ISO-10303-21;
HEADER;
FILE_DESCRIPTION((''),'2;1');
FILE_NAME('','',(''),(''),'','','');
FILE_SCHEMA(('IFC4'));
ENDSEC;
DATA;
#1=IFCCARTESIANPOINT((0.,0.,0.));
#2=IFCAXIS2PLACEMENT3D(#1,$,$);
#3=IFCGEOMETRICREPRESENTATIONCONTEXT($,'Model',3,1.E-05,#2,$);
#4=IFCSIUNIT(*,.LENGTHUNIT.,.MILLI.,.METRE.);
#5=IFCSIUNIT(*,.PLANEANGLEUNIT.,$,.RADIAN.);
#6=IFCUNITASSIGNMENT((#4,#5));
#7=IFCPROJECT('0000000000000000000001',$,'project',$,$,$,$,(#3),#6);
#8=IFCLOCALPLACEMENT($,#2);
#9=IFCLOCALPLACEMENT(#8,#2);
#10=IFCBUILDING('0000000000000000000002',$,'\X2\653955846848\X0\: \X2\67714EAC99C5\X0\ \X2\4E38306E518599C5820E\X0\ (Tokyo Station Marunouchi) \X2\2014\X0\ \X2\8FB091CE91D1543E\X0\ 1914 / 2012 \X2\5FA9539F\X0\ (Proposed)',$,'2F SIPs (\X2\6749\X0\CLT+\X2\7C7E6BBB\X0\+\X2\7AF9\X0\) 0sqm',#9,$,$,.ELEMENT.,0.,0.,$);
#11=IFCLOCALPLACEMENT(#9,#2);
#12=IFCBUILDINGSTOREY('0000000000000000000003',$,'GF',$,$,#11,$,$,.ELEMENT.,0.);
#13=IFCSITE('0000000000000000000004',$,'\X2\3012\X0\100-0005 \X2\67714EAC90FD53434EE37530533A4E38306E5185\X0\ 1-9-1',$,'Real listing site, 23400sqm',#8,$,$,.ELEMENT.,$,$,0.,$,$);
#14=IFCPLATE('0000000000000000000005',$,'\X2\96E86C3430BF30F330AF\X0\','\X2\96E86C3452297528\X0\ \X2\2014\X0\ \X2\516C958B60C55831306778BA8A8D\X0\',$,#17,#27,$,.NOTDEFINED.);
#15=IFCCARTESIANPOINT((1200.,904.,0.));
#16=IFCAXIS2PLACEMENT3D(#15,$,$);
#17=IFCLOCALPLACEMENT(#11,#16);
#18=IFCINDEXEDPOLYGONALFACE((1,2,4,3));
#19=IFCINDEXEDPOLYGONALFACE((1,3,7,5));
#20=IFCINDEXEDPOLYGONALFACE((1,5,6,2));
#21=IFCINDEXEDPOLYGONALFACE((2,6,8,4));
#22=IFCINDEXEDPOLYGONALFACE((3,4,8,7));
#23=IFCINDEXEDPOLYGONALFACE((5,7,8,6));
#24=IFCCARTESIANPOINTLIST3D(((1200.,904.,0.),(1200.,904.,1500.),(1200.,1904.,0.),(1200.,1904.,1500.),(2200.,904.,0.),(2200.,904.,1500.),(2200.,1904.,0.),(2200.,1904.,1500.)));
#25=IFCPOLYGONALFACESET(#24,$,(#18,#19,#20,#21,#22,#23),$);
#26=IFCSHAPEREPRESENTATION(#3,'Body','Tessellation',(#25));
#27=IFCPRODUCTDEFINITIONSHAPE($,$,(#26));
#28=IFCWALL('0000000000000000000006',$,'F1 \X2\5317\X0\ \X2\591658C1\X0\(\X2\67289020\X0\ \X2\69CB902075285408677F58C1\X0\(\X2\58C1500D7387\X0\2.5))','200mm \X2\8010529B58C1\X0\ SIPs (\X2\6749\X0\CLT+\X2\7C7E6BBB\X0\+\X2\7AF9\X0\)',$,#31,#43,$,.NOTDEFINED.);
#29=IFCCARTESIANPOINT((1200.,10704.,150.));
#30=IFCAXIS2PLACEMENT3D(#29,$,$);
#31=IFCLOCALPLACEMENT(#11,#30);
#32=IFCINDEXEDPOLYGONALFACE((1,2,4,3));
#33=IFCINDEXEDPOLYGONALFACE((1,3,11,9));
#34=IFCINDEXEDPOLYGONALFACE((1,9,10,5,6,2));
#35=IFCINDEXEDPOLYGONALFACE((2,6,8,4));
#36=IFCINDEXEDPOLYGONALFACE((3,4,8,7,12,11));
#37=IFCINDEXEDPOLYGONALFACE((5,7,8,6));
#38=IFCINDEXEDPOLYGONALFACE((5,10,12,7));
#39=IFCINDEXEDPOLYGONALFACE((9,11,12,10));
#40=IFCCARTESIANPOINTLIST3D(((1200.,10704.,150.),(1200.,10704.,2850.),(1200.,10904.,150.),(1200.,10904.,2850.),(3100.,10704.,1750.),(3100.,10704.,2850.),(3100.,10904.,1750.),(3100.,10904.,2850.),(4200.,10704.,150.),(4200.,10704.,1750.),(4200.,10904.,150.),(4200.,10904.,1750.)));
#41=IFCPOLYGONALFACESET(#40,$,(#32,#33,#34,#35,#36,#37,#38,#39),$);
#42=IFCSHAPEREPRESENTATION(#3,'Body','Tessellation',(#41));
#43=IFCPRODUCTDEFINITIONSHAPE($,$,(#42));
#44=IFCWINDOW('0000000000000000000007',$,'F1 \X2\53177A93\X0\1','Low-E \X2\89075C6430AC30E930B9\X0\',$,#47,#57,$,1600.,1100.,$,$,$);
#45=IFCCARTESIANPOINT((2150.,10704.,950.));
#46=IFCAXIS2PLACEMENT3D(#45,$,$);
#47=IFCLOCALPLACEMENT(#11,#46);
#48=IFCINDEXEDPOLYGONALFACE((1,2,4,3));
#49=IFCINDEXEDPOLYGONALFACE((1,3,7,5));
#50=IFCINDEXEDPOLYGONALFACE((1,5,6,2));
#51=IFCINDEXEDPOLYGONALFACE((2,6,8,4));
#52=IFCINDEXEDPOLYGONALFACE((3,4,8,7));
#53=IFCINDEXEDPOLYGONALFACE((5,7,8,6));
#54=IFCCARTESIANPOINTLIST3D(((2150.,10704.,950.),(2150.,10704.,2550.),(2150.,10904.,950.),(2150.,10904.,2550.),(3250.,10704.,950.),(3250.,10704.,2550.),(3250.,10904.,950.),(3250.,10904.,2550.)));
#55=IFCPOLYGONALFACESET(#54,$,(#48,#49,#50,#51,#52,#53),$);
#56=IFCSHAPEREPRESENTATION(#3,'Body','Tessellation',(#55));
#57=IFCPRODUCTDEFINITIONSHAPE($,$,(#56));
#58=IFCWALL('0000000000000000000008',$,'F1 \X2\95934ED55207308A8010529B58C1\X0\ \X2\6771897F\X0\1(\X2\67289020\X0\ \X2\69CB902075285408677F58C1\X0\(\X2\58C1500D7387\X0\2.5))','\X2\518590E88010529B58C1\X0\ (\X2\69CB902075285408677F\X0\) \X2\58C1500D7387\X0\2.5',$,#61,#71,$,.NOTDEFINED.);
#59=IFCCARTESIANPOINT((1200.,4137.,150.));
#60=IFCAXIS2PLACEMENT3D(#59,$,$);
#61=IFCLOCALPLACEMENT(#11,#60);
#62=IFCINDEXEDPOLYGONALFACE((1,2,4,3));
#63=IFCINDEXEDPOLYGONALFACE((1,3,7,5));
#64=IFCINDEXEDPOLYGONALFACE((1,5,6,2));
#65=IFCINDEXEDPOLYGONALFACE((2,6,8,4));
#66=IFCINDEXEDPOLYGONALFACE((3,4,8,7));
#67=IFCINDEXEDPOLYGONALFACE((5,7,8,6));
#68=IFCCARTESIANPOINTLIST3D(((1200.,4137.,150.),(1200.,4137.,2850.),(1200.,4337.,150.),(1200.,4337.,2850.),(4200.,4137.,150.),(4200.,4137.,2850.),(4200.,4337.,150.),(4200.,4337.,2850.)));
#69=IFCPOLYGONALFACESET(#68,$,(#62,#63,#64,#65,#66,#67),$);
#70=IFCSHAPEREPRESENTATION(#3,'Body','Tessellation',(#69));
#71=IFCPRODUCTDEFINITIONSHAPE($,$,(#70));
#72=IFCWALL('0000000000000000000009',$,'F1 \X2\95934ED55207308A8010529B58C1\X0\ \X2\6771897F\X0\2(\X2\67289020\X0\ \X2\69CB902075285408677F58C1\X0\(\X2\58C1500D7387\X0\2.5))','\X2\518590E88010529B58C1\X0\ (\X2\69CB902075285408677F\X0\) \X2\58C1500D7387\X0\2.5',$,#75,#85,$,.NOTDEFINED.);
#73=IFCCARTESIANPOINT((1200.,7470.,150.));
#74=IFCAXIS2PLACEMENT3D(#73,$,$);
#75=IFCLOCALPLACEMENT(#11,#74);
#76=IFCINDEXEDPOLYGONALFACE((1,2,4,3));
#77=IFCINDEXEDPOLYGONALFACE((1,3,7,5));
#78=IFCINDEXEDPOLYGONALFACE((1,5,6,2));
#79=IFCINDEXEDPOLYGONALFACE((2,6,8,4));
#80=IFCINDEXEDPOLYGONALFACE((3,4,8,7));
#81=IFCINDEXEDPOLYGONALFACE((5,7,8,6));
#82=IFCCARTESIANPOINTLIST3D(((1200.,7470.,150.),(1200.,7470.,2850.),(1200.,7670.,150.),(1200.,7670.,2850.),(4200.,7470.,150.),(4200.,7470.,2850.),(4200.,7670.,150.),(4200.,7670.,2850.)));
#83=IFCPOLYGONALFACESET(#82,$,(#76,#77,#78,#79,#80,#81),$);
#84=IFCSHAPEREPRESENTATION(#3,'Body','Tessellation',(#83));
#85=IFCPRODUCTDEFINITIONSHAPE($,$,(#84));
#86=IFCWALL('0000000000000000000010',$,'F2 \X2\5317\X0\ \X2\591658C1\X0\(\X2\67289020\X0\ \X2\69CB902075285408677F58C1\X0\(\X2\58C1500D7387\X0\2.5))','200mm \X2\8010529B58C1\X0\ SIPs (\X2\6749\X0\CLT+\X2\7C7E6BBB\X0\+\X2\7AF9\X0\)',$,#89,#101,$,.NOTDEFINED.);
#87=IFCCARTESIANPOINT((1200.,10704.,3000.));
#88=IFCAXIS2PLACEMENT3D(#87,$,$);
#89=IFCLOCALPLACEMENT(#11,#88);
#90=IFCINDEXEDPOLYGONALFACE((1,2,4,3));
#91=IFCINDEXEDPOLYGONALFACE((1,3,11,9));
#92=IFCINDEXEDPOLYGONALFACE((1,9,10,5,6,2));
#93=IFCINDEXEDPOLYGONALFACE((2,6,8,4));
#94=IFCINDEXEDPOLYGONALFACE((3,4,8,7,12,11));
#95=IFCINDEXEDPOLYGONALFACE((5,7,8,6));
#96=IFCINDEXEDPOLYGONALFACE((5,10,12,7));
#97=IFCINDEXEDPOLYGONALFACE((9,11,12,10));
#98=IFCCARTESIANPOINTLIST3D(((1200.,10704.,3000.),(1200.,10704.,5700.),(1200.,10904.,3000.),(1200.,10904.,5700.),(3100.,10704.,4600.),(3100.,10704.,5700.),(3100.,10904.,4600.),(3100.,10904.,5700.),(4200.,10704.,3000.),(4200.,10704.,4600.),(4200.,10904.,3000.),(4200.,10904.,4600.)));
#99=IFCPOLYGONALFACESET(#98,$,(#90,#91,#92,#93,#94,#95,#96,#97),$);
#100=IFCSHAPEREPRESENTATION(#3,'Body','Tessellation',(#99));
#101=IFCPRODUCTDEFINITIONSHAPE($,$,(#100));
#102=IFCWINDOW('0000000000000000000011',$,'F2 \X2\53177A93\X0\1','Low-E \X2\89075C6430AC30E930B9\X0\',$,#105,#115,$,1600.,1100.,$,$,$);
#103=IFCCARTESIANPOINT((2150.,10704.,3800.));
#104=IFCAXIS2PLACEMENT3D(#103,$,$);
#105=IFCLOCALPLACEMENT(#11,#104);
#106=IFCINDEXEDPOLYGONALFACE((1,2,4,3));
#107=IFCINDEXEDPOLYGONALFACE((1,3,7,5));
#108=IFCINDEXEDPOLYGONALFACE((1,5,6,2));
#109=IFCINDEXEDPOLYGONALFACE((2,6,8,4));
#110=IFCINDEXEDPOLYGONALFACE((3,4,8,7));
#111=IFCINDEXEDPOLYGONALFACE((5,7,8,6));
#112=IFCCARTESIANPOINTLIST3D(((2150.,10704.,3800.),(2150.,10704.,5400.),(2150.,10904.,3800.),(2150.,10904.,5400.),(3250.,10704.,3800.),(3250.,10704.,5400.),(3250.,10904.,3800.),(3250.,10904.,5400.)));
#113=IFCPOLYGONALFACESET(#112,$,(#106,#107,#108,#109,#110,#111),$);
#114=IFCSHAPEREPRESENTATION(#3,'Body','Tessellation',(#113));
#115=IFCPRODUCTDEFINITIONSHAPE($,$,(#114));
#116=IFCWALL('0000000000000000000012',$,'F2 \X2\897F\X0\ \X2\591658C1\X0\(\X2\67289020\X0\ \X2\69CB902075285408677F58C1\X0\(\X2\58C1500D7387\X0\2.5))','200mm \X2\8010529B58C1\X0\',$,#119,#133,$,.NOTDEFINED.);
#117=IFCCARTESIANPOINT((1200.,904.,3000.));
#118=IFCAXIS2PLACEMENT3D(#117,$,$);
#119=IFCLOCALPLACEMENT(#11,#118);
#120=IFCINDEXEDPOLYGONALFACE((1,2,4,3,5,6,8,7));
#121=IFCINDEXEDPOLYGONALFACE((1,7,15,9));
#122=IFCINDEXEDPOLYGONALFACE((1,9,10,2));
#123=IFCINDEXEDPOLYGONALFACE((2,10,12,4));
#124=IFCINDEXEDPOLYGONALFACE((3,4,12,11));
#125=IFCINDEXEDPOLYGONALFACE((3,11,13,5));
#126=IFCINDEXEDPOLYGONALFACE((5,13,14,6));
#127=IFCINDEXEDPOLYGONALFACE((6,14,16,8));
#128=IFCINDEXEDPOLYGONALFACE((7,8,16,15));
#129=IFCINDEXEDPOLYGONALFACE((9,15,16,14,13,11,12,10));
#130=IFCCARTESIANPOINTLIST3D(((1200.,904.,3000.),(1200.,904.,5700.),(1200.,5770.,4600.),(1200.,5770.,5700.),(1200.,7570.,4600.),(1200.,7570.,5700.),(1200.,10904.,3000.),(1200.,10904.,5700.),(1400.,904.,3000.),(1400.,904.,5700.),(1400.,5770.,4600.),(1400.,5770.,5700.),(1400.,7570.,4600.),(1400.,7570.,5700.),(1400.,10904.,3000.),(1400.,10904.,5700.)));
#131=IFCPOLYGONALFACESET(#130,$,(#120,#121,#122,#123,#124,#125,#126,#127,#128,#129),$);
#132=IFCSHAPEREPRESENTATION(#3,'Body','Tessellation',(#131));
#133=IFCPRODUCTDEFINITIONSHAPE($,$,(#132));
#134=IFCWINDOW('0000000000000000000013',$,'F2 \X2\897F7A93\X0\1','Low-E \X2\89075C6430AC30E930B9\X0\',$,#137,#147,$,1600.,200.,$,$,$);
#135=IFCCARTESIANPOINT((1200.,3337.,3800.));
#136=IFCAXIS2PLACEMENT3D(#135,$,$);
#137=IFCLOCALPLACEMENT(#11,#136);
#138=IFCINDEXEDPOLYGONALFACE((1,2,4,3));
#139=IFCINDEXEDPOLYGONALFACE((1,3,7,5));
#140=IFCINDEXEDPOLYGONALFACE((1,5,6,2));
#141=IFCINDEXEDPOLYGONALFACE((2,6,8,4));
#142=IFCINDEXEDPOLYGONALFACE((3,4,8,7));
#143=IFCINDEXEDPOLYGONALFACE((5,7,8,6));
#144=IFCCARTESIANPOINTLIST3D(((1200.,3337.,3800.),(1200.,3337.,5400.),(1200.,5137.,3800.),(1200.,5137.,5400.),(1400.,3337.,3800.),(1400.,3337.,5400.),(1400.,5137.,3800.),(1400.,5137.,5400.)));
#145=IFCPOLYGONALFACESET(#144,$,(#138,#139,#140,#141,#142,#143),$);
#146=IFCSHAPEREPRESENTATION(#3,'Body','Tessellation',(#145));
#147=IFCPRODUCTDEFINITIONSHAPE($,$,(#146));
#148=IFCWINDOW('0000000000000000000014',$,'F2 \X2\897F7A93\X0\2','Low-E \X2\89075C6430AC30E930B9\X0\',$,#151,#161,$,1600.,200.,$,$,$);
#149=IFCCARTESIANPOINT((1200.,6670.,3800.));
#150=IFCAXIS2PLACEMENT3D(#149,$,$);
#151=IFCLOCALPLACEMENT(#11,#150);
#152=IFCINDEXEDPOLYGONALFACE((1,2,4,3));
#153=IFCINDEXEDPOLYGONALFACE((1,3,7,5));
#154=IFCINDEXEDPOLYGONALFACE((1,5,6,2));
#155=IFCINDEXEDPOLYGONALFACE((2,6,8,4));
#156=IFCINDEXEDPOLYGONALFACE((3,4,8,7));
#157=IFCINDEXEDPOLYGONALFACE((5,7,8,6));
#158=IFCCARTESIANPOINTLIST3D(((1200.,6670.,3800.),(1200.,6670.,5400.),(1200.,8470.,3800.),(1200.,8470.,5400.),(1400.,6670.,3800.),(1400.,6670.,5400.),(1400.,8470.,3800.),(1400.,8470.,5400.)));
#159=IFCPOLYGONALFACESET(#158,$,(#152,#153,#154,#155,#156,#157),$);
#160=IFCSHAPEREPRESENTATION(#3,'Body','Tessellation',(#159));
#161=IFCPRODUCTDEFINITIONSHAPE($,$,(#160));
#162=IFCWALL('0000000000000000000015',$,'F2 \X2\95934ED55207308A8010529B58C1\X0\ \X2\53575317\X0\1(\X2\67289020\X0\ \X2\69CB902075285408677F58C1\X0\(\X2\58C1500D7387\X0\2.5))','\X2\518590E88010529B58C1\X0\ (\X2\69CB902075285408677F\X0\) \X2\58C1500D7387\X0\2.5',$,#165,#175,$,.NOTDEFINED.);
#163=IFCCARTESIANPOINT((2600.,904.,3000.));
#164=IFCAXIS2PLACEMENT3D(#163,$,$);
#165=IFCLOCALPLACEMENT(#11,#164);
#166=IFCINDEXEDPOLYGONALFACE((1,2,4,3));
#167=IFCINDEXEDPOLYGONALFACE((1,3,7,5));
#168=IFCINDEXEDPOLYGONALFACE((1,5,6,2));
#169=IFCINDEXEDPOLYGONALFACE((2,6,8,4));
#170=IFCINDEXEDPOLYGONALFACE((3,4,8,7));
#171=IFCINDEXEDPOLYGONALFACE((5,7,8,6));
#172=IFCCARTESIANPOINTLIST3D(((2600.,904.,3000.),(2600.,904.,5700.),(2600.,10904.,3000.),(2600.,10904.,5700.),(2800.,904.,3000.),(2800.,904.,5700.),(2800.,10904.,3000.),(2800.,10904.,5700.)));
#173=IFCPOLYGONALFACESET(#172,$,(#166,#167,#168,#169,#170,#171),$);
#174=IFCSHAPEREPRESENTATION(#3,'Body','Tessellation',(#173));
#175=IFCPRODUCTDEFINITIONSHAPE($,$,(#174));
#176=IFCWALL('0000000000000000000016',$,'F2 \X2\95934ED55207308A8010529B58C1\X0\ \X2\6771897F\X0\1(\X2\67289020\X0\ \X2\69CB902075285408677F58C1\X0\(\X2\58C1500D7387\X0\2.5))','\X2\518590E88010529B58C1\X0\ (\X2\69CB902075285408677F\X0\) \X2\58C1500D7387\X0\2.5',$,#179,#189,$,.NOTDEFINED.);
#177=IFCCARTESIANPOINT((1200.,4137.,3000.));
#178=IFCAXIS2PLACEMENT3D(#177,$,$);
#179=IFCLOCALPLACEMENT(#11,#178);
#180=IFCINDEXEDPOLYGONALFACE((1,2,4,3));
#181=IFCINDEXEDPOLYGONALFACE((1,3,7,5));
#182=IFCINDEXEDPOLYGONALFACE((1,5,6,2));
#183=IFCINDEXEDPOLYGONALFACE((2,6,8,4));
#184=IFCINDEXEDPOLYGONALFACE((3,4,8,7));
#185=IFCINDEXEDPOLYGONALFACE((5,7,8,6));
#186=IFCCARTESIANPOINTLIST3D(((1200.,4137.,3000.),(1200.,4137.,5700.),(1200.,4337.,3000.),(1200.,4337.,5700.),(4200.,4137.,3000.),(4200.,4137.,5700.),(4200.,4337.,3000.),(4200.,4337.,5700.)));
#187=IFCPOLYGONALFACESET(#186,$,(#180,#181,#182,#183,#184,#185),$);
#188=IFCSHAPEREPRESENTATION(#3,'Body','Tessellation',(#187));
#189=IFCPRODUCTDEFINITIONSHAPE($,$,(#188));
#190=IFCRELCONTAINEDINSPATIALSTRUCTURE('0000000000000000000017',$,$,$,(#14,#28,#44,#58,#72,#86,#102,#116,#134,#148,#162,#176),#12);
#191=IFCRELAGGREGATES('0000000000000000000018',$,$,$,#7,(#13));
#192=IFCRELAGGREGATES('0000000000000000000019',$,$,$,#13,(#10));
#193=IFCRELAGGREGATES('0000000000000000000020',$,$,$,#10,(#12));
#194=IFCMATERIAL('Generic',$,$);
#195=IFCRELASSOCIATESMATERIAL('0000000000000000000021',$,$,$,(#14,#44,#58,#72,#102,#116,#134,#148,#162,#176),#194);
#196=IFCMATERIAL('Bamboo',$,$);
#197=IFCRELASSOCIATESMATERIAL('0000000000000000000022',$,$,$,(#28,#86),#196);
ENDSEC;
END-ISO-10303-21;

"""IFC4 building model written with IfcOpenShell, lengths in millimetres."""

from ifc_helpers import new_model, si_unit, frame, frame_2d, origin, place, context, project, spatial, rectangle, extrude, material, element, fill, save


model = new_model("IFC4")

# Units and contexts
model_context = context("Model", 3, precision=1e-05, world=origin())
ifc_project = project(units=[si_unit("LENGTHUNIT", "METRE", prefix="MILLI"), si_unit("PLANEANGLEUNIT", "RADIAN")], contexts=[model_context])

# Site, building, storey
site_placement = place(None, origin())
site = spatial("IfcSite", under=ifc_project, at=site_placement, Name="〒100-0005 東京都千代田区丸の内 1-9-1", ObjectType="Real listing site, 23400sqm", CompositionType="ELEMENT", RefElevation=0.0)
building_placement = place(site_placement, origin())
building = spatial("IfcBuilding", under=site, at=building_placement, Name="改善案: 東京駅 丸の内駅舎 (Tokyo Station Marunouchi) — 辰野金吾 1914 / 2012 復原 (Proposed)", ObjectType="2F SIPs (杉CLT+籾殻+竹) 0sqm", CompositionType="ELEMENT", ElevationOfRefHeight=0.0, ElevationOfTerrain=0.0)
storey_placement = place(building_placement, origin())
storey = spatial("IfcBuildingStorey", under=building, at=storey_placement, Name="GF", CompositionType="ELEMENT", Elevation=0.0)

# Plate
ifc_material_1 = material(Name="Generic")
plate_placement = place(storey_placement, frame((1200.0, 904.0, 0.0)))
element("IfcPlate", 1, at=plate_placement, inside=storey, material=ifc_material_1, Name="雨水タンク", Description="雨水利用 — 公開情報で確認", PredefinedType="NOTDEFINED", context=model_context, shape_type="SweptSolid", body=[
    extrude(rectangle(XDim=1000.0, YDim=1000.0, at=frame_2d((500.0, 500.0))), frame((1200.0, 904.0, 0.0)), (0.0, 0.0, 1.0), 1500.0),
])

# Wall, opening, window
ifc_material_2 = material(Name="Bamboo")
wall_1_placement = place(storey_placement, frame((1200.0, 10704.0, 150.0)))
wall_1 = element("IfcWall", 2, at=wall_1_placement, inside=storey, material=ifc_material_2, Name="F1 北 外壁(木造 構造用合板壁(壁倍率2.5))", Description="200mm 耐力壁 SIPs (杉CLT+籾殻+竹)", PredefinedType="NOTDEFINED", context=model_context, shape_type="SweptSolid", body=[
    extrude(rectangle(XDim=3000.0, YDim=200.0, at=frame_2d((1500.0, 100.0))), frame((1200.0, 10704.0, 150.0)), (0.0, 0.0, 1.0), 2700.0),
])
opening_1_placement = place(storey_placement, frame((2150.0, 10704.0, 950.0)))
opening_1 = element("IfcOpeningElement", 3, at=opening_1_placement, cuts=wall_1, PredefinedType="NOTDEFINED", context=model_context, shape_type="SweptSolid", body=[
    extrude(rectangle(XDim=1100.0, YDim=200.0, at=frame_2d((550.0, 100.0))), frame((2150.0, 10704.0, 950.0)), (0.0, 0.0, 1.0), 1600.0),
])
window_1_placement = place(storey_placement, frame((2150.0, 10704.0, 950.0)))
window_1 = element("IfcWindow", 4, at=window_1_placement, inside=storey, material=ifc_material_1, Name="F1 北窓1", Description="Low-E 複層ガラス", OverallHeight=1600.0, OverallWidth=1100.0, context=model_context, shape_type="SweptSolid", body=[
    extrude(rectangle(XDim=1100.0, YDim=200.0, at=frame_2d((550.0, 100.0))), frame((2150.0, 10704.0, 950.0)), (0.0, 0.0, 1.0), 1600.0),
])
fill(opening_1, window_1)

# Walls
wall_2_placement = place(storey_placement, frame((1200.0, 4137.0, 150.0)))
element("IfcWall", 5, at=wall_2_placement, inside=storey, material=ifc_material_1, Name="F1 間仕切り耐力壁 東西1(木造 構造用合板壁(壁倍率2.5))", Description="内部耐力壁 (構造用合板) 壁倍率2.5", PredefinedType="NOTDEFINED", context=model_context, shape_type="SweptSolid", body=[
    extrude(rectangle(XDim=3000.0, YDim=200.0, at=frame_2d((1500.0, 100.0))), frame((1200.0, 4137.0, 150.0)), (0.0, 0.0, 1.0), 2700.0),
])
wall_3_placement = place(storey_placement, frame((1200.0, 7470.0, 150.0)))
element("IfcWall", 6, at=wall_3_placement, inside=storey, material=ifc_material_1, Name="F1 間仕切り耐力壁 東西2(木造 構造用合板壁(壁倍率2.5))", Description="内部耐力壁 (構造用合板) 壁倍率2.5", PredefinedType="NOTDEFINED", context=model_context, shape_type="SweptSolid", body=[
    extrude(rectangle(XDim=3000.0, YDim=200.0, at=frame_2d((1500.0, 100.0))), frame((1200.0, 7470.0, 150.0)), (0.0, 0.0, 1.0), 2700.0),
])

# Wall, opening, window
wall_4_placement = place(storey_placement, frame((1200.0, 10704.0, 3000.0)))
wall_4 = element("IfcWall", 7, at=wall_4_placement, inside=storey, material=ifc_material_2, Name="F2 北 外壁(木造 構造用合板壁(壁倍率2.5))", Description="200mm 耐力壁 SIPs (杉CLT+籾殻+竹)", PredefinedType="NOTDEFINED", context=model_context, shape_type="SweptSolid", body=[
    extrude(rectangle(XDim=3000.0, YDim=200.0, at=frame_2d((1500.0, 100.0))), frame((1200.0, 10704.0, 3000.0)), (0.0, 0.0, 1.0), 2700.0),
])
opening_2_placement = place(storey_placement, frame((2150.0, 10704.0, 3800.0)))
opening_2 = element("IfcOpeningElement", 8, at=opening_2_placement, cuts=wall_4, PredefinedType="NOTDEFINED", context=model_context, shape_type="SweptSolid", body=[
    extrude(rectangle(XDim=1100.0, YDim=200.0, at=frame_2d((550.0, 100.0))), frame((2150.0, 10704.0, 3800.0)), (0.0, 0.0, 1.0), 1600.0),
])
window_2_placement = place(storey_placement, frame((2150.0, 10704.0, 3800.0)))
window_2 = element("IfcWindow", 9, at=window_2_placement, inside=storey, material=ifc_material_1, Name="F2 北窓1", Description="Low-E 複層ガラス", OverallHeight=1600.0, OverallWidth=1100.0, context=model_context, shape_type="SweptSolid", body=[
    extrude(rectangle(XDim=1100.0, YDim=200.0, at=frame_2d((550.0, 100.0))), frame((2150.0, 10704.0, 3800.0)), (0.0, 0.0, 1.0), 1600.0),
])
fill(opening_2, window_2)

# Wall, openings, windows
wall_5_placement = place(storey_placement, frame((1200.0, 904.0, 3000.0)))
wall_5 = element("IfcWall", 10, at=wall_5_placement, inside=storey, material=ifc_material_1, Name="F2 西 外壁(木造 構造用合板壁(壁倍率2.5))", Description="200mm 耐力壁", PredefinedType="NOTDEFINED", context=model_context, shape_type="SweptSolid", body=[
    extrude(rectangle(XDim=200.0, YDim=10000.0, at=frame_2d((100.0, 5000.0))), frame((1200.0, 904.0, 3000.0)), (0.0, 0.0, 1.0), 2700.0),
])
opening_3_placement = place(storey_placement, frame((1200.0, 3337.0, 3800.0)))
opening_3 = element("IfcOpeningElement", 11, at=opening_3_placement, cuts=wall_5, PredefinedType="NOTDEFINED", context=model_context, shape_type="SweptSolid", body=[
    extrude(rectangle(XDim=200.0, YDim=1800.0, at=frame_2d((100.0, 900.0))), frame((1200.0, 3337.0, 3800.0)), (0.0, 0.0, 1.0), 1600.0),
])
opening_4_placement = place(storey_placement, frame((1200.0, 6670.0, 3800.0)))
opening_4 = element("IfcOpeningElement", 12, at=opening_4_placement, cuts=wall_5, PredefinedType="NOTDEFINED", context=model_context, shape_type="SweptSolid", body=[
    extrude(rectangle(XDim=200.0, YDim=1800.0, at=frame_2d((100.0, 900.0))), frame((1200.0, 6670.0, 3800.0)), (0.0, 0.0, 1.0), 1600.0),
])
window_3_placement = place(storey_placement, frame((1200.0, 3337.0, 3800.0)))
window_3 = element("IfcWindow", 13, at=window_3_placement, inside=storey, material=ifc_material_1, Name="F2 西窓1", Description="Low-E 複層ガラス", OverallHeight=1600.0, OverallWidth=200.0, context=model_context, shape_type="SweptSolid", body=[
    extrude(rectangle(XDim=200.0, YDim=1800.0, at=frame_2d((100.0, 900.0))), frame((1200.0, 3337.0, 3800.0)), (0.0, 0.0, 1.0), 1600.0),
])
fill(opening_3, window_3)
window_4_placement = place(storey_placement, frame((1200.0, 6670.0, 3800.0)))
window_4 = element("IfcWindow", 14, at=window_4_placement, inside=storey, material=ifc_material_1, Name="F2 西窓2", Description="Low-E 複層ガラス", OverallHeight=1600.0, OverallWidth=200.0, context=model_context, shape_type="SweptSolid", body=[
    extrude(rectangle(XDim=200.0, YDim=1800.0, at=frame_2d((100.0, 900.0))), frame((1200.0, 6670.0, 3800.0)), (0.0, 0.0, 1.0), 1600.0),
])
fill(opening_4, window_4)

# Walls
wall_6_placement = place(storey_placement, frame((2600.0, 904.0, 3000.0)))
element("IfcWall", 15, at=wall_6_placement, inside=storey, material=ifc_material_1, Name="F2 間仕切り耐力壁 南北1(木造 構造用合板壁(壁倍率2.5))", Description="内部耐力壁 (構造用合板) 壁倍率2.5", PredefinedType="NOTDEFINED", context=model_context, shape_type="SweptSolid", body=[
    extrude(rectangle(XDim=200.0, YDim=10000.0, at=frame_2d((100.0, 5000.0))), frame((2600.0, 904.0, 3000.0)), (0.0, 0.0, 1.0), 2700.0),
])
wall_7_placement = place(storey_placement, frame((1200.0, 4137.0, 3000.0)))
element("IfcWall", 16, at=wall_7_placement, inside=storey, material=ifc_material_1, Name="F2 間仕切り耐力壁 東西1(木造 構造用合板壁(壁倍率2.5))", Description="内部耐力壁 (構造用合板) 壁倍率2.5", PredefinedType="NOTDEFINED", context=model_context, shape_type="SweptSolid", body=[
    extrude(rectangle(XDim=3000.0, YDim=200.0, at=frame_2d((1500.0, 100.0))), frame((1200.0, 4137.0, 3000.0)), (0.0, 0.0, 1.0), 2700.0),
])

save(model, "model.ifc")
